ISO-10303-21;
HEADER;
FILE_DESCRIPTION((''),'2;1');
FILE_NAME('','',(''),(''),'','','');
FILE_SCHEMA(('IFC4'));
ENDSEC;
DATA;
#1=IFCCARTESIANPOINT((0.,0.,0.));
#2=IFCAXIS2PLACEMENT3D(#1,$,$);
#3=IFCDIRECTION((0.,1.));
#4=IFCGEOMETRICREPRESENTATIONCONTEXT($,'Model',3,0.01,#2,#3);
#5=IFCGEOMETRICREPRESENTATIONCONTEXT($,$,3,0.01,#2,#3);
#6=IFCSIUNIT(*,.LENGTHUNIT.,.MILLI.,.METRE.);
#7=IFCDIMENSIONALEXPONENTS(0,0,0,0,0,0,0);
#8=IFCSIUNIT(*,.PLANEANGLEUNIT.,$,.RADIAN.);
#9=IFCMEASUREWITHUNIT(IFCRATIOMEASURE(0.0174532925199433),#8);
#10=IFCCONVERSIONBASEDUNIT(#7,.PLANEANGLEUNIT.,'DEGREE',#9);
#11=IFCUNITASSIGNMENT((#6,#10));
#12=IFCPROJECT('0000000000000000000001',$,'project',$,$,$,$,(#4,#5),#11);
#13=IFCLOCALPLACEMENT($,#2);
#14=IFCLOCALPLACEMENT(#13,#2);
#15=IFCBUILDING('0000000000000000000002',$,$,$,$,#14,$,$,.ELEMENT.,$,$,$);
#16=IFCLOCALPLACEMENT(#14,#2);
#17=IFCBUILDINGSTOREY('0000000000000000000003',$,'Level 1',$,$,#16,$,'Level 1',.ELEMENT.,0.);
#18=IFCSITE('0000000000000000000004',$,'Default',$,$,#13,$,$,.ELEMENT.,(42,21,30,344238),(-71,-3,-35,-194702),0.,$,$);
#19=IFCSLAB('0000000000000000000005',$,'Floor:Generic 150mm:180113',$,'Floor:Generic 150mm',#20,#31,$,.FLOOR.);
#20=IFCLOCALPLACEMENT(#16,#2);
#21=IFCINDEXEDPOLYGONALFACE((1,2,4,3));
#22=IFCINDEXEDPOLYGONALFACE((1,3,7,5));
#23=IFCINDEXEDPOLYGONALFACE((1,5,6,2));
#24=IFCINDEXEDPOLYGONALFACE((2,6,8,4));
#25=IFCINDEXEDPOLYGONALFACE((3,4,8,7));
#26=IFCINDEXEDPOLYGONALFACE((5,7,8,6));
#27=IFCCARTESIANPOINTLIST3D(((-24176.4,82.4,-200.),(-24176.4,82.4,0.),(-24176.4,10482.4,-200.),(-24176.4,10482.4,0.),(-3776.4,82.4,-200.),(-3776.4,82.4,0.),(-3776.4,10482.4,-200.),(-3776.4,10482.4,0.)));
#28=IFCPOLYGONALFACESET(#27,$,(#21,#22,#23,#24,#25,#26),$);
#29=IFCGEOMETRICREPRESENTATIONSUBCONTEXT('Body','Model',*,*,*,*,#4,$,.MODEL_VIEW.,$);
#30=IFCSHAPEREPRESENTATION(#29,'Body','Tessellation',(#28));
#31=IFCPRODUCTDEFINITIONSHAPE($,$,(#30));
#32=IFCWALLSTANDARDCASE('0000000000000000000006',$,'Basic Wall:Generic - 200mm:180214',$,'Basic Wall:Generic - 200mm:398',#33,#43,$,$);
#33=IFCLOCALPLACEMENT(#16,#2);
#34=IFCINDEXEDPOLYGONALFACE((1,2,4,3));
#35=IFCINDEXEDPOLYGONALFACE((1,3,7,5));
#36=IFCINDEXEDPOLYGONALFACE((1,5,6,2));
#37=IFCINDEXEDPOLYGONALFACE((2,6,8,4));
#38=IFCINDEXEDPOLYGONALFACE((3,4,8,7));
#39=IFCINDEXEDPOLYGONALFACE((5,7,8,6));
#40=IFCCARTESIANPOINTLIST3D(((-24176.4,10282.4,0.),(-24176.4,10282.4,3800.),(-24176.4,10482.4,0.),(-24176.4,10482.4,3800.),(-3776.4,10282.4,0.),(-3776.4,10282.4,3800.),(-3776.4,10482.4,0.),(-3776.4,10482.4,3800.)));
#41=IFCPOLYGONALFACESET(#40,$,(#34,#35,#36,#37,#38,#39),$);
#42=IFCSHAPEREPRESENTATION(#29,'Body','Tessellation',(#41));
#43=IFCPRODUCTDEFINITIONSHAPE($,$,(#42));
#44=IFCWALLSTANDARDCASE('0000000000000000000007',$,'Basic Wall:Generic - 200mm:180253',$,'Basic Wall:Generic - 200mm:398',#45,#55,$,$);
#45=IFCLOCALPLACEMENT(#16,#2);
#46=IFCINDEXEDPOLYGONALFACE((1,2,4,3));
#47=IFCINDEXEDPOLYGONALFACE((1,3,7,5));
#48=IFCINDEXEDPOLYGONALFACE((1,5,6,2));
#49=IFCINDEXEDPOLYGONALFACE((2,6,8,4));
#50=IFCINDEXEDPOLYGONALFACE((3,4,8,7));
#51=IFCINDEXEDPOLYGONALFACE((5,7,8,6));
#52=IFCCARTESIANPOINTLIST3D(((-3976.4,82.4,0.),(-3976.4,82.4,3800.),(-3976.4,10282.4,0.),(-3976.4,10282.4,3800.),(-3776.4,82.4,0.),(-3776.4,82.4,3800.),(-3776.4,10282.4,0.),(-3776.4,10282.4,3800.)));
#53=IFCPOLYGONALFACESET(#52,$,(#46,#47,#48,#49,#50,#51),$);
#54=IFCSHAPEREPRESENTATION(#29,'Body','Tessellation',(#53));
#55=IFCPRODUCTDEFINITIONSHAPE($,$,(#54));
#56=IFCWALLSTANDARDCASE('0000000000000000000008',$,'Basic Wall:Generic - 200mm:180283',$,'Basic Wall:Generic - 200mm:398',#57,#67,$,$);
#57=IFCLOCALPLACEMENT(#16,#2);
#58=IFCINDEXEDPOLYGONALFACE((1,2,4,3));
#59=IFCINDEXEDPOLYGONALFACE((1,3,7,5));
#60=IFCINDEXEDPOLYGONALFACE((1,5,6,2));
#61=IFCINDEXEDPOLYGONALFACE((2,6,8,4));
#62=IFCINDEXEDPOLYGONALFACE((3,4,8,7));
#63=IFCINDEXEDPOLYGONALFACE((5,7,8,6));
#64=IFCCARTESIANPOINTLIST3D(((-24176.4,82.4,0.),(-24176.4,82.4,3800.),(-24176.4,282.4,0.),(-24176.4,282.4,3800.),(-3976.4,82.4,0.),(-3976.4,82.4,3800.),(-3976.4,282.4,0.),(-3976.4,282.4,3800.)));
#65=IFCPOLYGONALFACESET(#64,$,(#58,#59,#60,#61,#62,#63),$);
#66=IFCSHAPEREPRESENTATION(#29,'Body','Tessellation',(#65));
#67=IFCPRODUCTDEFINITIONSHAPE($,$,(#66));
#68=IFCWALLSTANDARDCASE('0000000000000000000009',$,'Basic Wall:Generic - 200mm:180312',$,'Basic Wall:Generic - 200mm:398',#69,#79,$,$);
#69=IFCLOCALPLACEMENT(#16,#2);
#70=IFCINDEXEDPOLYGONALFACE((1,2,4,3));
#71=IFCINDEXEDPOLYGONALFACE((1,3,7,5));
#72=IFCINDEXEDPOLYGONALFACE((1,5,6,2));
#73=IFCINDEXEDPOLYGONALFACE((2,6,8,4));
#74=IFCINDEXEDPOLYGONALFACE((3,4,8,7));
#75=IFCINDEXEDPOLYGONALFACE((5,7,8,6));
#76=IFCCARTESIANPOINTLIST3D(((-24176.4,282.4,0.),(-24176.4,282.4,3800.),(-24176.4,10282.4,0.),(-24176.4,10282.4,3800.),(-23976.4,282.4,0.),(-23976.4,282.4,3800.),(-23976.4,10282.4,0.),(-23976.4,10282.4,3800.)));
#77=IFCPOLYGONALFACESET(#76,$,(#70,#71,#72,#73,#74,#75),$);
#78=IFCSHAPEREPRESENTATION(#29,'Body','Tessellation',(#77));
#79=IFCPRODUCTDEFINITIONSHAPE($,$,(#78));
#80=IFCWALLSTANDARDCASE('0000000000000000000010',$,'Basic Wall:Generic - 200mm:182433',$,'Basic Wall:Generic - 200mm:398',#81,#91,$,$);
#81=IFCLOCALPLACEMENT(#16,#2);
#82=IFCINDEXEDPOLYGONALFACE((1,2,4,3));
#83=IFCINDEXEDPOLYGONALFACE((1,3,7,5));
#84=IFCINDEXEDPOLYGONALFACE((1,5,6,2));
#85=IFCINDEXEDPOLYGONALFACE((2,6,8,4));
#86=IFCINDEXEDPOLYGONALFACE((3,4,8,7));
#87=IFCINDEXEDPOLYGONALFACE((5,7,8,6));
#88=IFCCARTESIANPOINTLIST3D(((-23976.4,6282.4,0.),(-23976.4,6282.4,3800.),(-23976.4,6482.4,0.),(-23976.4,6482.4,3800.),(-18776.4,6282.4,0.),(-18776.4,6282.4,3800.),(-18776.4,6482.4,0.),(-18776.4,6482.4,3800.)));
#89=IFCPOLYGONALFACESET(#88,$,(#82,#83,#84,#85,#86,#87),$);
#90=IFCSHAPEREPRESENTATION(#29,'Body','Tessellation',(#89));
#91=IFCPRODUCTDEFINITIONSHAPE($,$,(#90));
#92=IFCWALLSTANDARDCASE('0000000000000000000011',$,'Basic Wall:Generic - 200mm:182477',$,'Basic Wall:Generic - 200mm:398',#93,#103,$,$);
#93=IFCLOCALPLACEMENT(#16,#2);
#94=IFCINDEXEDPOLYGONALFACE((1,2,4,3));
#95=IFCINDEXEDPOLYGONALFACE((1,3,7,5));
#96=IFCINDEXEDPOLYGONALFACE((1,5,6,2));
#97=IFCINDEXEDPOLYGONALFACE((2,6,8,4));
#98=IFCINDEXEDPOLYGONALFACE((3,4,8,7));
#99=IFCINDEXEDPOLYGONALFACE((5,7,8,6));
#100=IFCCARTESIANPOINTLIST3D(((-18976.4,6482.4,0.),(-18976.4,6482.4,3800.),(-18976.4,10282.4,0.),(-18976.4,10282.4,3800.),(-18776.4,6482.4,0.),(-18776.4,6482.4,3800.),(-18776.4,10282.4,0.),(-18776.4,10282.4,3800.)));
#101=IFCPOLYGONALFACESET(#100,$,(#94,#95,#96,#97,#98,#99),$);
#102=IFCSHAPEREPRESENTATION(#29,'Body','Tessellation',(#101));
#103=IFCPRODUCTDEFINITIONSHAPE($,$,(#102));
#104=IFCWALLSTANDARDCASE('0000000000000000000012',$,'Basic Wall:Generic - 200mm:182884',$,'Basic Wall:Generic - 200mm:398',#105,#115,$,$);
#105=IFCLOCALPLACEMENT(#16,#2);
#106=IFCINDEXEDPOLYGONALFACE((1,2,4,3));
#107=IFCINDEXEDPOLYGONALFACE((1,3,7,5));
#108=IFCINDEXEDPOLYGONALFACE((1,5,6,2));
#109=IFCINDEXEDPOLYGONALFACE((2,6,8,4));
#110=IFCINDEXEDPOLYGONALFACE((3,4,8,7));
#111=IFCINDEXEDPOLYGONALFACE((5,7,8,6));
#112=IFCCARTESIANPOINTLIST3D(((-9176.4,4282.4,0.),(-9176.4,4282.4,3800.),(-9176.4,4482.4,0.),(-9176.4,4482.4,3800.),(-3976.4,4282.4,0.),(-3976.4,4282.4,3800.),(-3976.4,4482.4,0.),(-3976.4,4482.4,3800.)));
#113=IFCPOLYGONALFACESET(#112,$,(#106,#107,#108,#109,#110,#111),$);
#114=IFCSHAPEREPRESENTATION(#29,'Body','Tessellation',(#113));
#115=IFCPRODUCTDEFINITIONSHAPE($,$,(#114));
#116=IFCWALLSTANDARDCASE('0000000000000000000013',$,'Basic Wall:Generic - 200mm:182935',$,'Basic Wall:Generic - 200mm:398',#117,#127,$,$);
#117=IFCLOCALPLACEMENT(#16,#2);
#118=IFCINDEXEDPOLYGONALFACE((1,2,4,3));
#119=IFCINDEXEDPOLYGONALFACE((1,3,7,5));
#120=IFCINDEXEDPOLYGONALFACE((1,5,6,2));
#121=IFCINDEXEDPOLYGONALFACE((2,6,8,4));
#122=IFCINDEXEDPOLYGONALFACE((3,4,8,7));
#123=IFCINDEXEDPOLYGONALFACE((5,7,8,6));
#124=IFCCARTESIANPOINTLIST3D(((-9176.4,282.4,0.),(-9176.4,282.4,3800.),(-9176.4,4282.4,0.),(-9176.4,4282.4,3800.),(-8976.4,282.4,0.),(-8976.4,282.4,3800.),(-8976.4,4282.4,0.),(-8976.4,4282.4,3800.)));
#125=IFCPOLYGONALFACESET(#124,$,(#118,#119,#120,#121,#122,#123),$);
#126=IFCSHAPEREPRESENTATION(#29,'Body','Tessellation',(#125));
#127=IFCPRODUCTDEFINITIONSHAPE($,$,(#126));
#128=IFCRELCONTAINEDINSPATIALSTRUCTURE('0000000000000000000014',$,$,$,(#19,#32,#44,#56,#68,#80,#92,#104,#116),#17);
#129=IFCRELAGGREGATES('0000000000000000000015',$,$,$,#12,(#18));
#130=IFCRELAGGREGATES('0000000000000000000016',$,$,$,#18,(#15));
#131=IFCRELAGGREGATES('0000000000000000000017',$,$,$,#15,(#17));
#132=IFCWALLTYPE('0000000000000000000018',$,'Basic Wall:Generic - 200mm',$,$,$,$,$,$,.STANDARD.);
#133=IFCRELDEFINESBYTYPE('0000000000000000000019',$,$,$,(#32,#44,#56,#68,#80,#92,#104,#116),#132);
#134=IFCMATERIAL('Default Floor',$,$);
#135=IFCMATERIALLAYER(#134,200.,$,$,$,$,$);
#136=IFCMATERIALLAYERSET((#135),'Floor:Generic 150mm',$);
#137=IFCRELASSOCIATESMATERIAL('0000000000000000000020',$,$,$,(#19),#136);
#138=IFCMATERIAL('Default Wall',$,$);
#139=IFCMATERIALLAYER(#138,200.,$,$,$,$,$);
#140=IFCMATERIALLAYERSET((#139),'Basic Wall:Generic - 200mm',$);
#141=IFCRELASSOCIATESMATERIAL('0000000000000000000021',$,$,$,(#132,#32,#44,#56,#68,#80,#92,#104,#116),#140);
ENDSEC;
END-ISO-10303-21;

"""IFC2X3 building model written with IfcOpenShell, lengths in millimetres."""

from ifc_helpers import new_model, entity, si_unit, converted_unit, direction, frame, frame_2d, origin, origin_2d_with_axis, place, context, subcontext, project, spatial, rectangle, extrude, material, layer, layer_set, layer_usage, type_object, element, save


model = new_model("IFC2X3")

# Units and contexts
model_context = context("Model", 3, precision=0.01, world=origin(), true_north=direction((0.0, 1.0)))
context_of_model = context(None, 3, precision=0.01, world=origin(), true_north=direction((0.0, 1.0)))
body_context = subcontext(model_context, "Body", "Model", "MODEL_VIEW")
ifc_project = project(units=[si_unit("LENGTHUNIT", "METRE", prefix="MILLI"), converted_unit("PLANEANGLEUNIT", "DEGREE", entity("IfcRatioMeasure", 0.0174532925199433), si_unit("PLANEANGLEUNIT", "RADIAN"), dimensions=[0, 0, 0, 0, 0, 0, 0])], contexts=[model_context, context_of_model])

# Site, building, storey
site_placement = place(None, origin())
site = spatial("IfcSite", under=ifc_project, at=site_placement, Name="Default", CompositionType="ELEMENT", RefLatitude=(42, 21, 30, 344238), RefLongitude=(-71, -3, -35, -194702), RefElevation=0.0)
building_placement = place(site_placement, origin())
building = spatial("IfcBuilding", under=site, at=building_placement, CompositionType="ELEMENT")
storey_placement = place(building_placement, origin())
storey = spatial("IfcBuildingStorey", under=building, at=storey_placement, Name="Level 1", LongName="Level 1", CompositionType="ELEMENT", Elevation=0.0)

# Slab
ifc_material_1 = material(Name="Default Floor")
ifc_layer_1 = layer(ifc_material_1, 200.0)
ifc_layer_set_1 = layer_set([ifc_layer_1], Name="Floor:Generic 150mm")
ifc_layer_usage_1 = layer_usage(ifc_layer_set_1, "AXIS3", "POSITIVE", 0.0)
slab_placement = place(storey_placement, origin())
element("IfcSlab", 1, at=slab_placement, inside=storey, material=ifc_layer_usage_1, Name="Floor:Generic 150mm:180113", ObjectType="Floor:Generic 150mm", PredefinedType="FLOOR", context=body_context, shape_type="SweptSolid", body=[
    extrude(rectangle(XDim=10400.0, YDim=20400.0, at=origin_2d_with_axis()), frame((-13976.4, 5282.4, 0.0), z_axis=(0.0, 0.0, -1.0), x_axis=(0.0, 1.0, 0.0)), (0.0, 0.0, 1.0), 200.0),
])

# Walls
ifc_material_2 = material(Name="Default Wall")
ifc_layer_2 = layer(ifc_material_2, 200.0)
ifc_layer_set_2 = layer_set([ifc_layer_2], Name="Basic Wall:Generic - 200mm")
ifc_layer_usage_2 = layer_usage(ifc_layer_set_2, "AXIS2", "NEGATIVE", 100.0)
wall_type = type_object("IfcWallType", Name="Basic Wall:Generic - 200mm", PredefinedType="STANDARD", material=ifc_layer_set_2)
wall_1_placement = place(storey_placement, frame((-24176.4, 10382.4, 0.0)))
element("IfcWallStandardCase", 2, at=wall_1_placement, inside=storey, type_object=wall_type, material=ifc_layer_usage_2, Name="Basic Wall:Generic - 200mm:180214", ObjectType="Basic Wall:Generic - 200mm:398", context=body_context, shape_type="SweptSolid", body=[
    extrude(rectangle(XDim=20400.0, YDim=200.0, at=frame_2d((10200.0, 0.0), x_axis=(-1.0, 0.0))), origin(), (0.0, 0.0, 1.0), 3800.0),
])
ifc_layer_usage_3 = layer_usage(ifc_layer_set_2, "AXIS2", "NEGATIVE", 100.0)
wall_2_placement = place(storey_placement, frame((-3876.4, 10282.4, 0.0), z_axis=(0.0, 0.0, 1.0), x_axis=(0.0, -1.0, 0.0)))
element("IfcWallStandardCase", 3, at=wall_2_placement, inside=storey, type_object=wall_type, material=ifc_layer_usage_3, Name="Basic Wall:Generic - 200mm:180253", ObjectType="Basic Wall:Generic - 200mm:398", context=body_context, shape_type="SweptSolid", body=[
    extrude(rectangle(XDim=10200.0, YDim=200.0, at=frame_2d((5100.0, 0.0), x_axis=(-1.0, 0.0))), origin(), (0.0, 0.0, 1.0), 3800.0),
])
ifc_layer_usage_4 = layer_usage(ifc_layer_set_2, "AXIS2", "NEGATIVE", 100.0)
wall_3_placement = place(storey_placement, frame((-3976.4, 182.4, 0.0), z_axis=(0.0, 0.0, 1.0), x_axis=(-1.0, 0.0, 0.0)))
element("IfcWallStandardCase", 4, at=wall_3_placement, inside=storey, type_object=wall_type, material=ifc_layer_usage_4, Name="Basic Wall:Generic - 200mm:180283", ObjectType="Basic Wall:Generic - 200mm:398", context=body_context, shape_type="SweptSolid", body=[
    extrude(rectangle(XDim=20200.0, YDim=200.0, at=frame_2d((10100.0, 0.0), x_axis=(-1.0, 0.0))), origin(), (0.0, 0.0, 1.0), 3800.0),
])
ifc_layer_usage_5 = layer_usage(ifc_layer_set_2, "AXIS2", "NEGATIVE", 100.0)
wall_4_placement = place(storey_placement, frame((-24076.4, 282.4, 0.0), z_axis=(0.0, 0.0, 1.0), x_axis=(0.0, 1.0, 0.0)))
element("IfcWallStandardCase", 5, at=wall_4_placement, inside=storey, type_object=wall_type, material=ifc_layer_usage_5, Name="Basic Wall:Generic - 200mm:180312", ObjectType="Basic Wall:Generic - 200mm:398", context=body_context, shape_type="SweptSolid", body=[
    extrude(rectangle(XDim=10000.0, YDim=200.0, at=frame_2d((5000.0, 0.0), x_axis=(-1.0, 0.0))), origin(), (0.0, 0.0, 1.0), 3800.0),
])
ifc_layer_usage_6 = layer_usage(ifc_layer_set_2, "AXIS2", "NEGATIVE", 100.0)
wall_5_placement = place(storey_placement, frame((-23976.4, 6382.4, 0.0)))
element("IfcWallStandardCase", 6, at=wall_5_placement, inside=storey, type_object=wall_type, material=ifc_layer_usage_6, Name="Basic Wall:Generic - 200mm:182433", ObjectType="Basic Wall:Generic - 200mm:398", context=body_context, shape_type="SweptSolid", body=[
    extrude(rectangle(XDim=5200.0, YDim=200.0, at=frame_2d((2600.0, 0.0), x_axis=(-1.0, 0.0))), origin(), (0.0, 0.0, 1.0), 3800.0),
])
ifc_layer_usage_7 = layer_usage(ifc_layer_set_2, "AXIS2", "NEGATIVE", 100.0)
wall_6_placement = place(storey_placement, frame((-18876.4, 6482.4, 0.0), z_axis=(0.0, 0.0, 1.0), x_axis=(0.0, 1.0, 0.0)))
element("IfcWallStandardCase", 7, at=wall_6_placement, inside=storey, type_object=wall_type, material=ifc_layer_usage_7, Name="Basic Wall:Generic - 200mm:182477", ObjectType="Basic Wall:Generic - 200mm:398", context=body_context, shape_type="SweptSolid", body=[
    extrude(rectangle(XDim=3800.0, YDim=200.0, at=frame_2d((1900.0, 0.0), x_axis=(-1.0, 0.0))), origin(), (0.0, 0.0, 1.0), 3800.0),
])
ifc_layer_usage_8 = layer_usage(ifc_layer_set_2, "AXIS2", "NEGATIVE", 100.0)
wall_7_placement = place(storey_placement, frame((-3976.4, 4382.4, 0.0), z_axis=(0.0, 0.0, 1.0), x_axis=(-1.0, 0.0, 0.0)))
element("IfcWallStandardCase", 8, at=wall_7_placement, inside=storey, type_object=wall_type, material=ifc_layer_usage_8, Name="Basic Wall:Generic - 200mm:182884", ObjectType="Basic Wall:Generic - 200mm:398", context=body_context, shape_type="SweptSolid", body=[
    extrude(rectangle(XDim=5200.0, YDim=200.0, at=frame_2d((2600.0, 0.0), x_axis=(-1.0, 0.0))), origin(), (0.0, 0.0, 1.0), 3800.0),
])
ifc_layer_usage_9 = layer_usage(ifc_layer_set_2, "AXIS2", "NEGATIVE", 100.0)
wall_8_placement = place(storey_placement, frame((-9076.4, 4282.4, 0.0), z_axis=(0.0, 0.0, 1.0), x_axis=(0.0, -1.0, 0.0)))
element("IfcWallStandardCase", 9, at=wall_8_placement, inside=storey, type_object=wall_type, material=ifc_layer_usage_9, Name="Basic Wall:Generic - 200mm:182935", ObjectType="Basic Wall:Generic - 200mm:398", context=body_context, shape_type="SweptSolid", body=[
    extrude(rectangle(XDim=4000.0, YDim=200.0, at=frame_2d((2000.0, 0.0), x_axis=(-1.0, 0.0))), origin(), (0.0, 0.0, 1.0), 3800.0),
])

save(model, "model.ifc")
